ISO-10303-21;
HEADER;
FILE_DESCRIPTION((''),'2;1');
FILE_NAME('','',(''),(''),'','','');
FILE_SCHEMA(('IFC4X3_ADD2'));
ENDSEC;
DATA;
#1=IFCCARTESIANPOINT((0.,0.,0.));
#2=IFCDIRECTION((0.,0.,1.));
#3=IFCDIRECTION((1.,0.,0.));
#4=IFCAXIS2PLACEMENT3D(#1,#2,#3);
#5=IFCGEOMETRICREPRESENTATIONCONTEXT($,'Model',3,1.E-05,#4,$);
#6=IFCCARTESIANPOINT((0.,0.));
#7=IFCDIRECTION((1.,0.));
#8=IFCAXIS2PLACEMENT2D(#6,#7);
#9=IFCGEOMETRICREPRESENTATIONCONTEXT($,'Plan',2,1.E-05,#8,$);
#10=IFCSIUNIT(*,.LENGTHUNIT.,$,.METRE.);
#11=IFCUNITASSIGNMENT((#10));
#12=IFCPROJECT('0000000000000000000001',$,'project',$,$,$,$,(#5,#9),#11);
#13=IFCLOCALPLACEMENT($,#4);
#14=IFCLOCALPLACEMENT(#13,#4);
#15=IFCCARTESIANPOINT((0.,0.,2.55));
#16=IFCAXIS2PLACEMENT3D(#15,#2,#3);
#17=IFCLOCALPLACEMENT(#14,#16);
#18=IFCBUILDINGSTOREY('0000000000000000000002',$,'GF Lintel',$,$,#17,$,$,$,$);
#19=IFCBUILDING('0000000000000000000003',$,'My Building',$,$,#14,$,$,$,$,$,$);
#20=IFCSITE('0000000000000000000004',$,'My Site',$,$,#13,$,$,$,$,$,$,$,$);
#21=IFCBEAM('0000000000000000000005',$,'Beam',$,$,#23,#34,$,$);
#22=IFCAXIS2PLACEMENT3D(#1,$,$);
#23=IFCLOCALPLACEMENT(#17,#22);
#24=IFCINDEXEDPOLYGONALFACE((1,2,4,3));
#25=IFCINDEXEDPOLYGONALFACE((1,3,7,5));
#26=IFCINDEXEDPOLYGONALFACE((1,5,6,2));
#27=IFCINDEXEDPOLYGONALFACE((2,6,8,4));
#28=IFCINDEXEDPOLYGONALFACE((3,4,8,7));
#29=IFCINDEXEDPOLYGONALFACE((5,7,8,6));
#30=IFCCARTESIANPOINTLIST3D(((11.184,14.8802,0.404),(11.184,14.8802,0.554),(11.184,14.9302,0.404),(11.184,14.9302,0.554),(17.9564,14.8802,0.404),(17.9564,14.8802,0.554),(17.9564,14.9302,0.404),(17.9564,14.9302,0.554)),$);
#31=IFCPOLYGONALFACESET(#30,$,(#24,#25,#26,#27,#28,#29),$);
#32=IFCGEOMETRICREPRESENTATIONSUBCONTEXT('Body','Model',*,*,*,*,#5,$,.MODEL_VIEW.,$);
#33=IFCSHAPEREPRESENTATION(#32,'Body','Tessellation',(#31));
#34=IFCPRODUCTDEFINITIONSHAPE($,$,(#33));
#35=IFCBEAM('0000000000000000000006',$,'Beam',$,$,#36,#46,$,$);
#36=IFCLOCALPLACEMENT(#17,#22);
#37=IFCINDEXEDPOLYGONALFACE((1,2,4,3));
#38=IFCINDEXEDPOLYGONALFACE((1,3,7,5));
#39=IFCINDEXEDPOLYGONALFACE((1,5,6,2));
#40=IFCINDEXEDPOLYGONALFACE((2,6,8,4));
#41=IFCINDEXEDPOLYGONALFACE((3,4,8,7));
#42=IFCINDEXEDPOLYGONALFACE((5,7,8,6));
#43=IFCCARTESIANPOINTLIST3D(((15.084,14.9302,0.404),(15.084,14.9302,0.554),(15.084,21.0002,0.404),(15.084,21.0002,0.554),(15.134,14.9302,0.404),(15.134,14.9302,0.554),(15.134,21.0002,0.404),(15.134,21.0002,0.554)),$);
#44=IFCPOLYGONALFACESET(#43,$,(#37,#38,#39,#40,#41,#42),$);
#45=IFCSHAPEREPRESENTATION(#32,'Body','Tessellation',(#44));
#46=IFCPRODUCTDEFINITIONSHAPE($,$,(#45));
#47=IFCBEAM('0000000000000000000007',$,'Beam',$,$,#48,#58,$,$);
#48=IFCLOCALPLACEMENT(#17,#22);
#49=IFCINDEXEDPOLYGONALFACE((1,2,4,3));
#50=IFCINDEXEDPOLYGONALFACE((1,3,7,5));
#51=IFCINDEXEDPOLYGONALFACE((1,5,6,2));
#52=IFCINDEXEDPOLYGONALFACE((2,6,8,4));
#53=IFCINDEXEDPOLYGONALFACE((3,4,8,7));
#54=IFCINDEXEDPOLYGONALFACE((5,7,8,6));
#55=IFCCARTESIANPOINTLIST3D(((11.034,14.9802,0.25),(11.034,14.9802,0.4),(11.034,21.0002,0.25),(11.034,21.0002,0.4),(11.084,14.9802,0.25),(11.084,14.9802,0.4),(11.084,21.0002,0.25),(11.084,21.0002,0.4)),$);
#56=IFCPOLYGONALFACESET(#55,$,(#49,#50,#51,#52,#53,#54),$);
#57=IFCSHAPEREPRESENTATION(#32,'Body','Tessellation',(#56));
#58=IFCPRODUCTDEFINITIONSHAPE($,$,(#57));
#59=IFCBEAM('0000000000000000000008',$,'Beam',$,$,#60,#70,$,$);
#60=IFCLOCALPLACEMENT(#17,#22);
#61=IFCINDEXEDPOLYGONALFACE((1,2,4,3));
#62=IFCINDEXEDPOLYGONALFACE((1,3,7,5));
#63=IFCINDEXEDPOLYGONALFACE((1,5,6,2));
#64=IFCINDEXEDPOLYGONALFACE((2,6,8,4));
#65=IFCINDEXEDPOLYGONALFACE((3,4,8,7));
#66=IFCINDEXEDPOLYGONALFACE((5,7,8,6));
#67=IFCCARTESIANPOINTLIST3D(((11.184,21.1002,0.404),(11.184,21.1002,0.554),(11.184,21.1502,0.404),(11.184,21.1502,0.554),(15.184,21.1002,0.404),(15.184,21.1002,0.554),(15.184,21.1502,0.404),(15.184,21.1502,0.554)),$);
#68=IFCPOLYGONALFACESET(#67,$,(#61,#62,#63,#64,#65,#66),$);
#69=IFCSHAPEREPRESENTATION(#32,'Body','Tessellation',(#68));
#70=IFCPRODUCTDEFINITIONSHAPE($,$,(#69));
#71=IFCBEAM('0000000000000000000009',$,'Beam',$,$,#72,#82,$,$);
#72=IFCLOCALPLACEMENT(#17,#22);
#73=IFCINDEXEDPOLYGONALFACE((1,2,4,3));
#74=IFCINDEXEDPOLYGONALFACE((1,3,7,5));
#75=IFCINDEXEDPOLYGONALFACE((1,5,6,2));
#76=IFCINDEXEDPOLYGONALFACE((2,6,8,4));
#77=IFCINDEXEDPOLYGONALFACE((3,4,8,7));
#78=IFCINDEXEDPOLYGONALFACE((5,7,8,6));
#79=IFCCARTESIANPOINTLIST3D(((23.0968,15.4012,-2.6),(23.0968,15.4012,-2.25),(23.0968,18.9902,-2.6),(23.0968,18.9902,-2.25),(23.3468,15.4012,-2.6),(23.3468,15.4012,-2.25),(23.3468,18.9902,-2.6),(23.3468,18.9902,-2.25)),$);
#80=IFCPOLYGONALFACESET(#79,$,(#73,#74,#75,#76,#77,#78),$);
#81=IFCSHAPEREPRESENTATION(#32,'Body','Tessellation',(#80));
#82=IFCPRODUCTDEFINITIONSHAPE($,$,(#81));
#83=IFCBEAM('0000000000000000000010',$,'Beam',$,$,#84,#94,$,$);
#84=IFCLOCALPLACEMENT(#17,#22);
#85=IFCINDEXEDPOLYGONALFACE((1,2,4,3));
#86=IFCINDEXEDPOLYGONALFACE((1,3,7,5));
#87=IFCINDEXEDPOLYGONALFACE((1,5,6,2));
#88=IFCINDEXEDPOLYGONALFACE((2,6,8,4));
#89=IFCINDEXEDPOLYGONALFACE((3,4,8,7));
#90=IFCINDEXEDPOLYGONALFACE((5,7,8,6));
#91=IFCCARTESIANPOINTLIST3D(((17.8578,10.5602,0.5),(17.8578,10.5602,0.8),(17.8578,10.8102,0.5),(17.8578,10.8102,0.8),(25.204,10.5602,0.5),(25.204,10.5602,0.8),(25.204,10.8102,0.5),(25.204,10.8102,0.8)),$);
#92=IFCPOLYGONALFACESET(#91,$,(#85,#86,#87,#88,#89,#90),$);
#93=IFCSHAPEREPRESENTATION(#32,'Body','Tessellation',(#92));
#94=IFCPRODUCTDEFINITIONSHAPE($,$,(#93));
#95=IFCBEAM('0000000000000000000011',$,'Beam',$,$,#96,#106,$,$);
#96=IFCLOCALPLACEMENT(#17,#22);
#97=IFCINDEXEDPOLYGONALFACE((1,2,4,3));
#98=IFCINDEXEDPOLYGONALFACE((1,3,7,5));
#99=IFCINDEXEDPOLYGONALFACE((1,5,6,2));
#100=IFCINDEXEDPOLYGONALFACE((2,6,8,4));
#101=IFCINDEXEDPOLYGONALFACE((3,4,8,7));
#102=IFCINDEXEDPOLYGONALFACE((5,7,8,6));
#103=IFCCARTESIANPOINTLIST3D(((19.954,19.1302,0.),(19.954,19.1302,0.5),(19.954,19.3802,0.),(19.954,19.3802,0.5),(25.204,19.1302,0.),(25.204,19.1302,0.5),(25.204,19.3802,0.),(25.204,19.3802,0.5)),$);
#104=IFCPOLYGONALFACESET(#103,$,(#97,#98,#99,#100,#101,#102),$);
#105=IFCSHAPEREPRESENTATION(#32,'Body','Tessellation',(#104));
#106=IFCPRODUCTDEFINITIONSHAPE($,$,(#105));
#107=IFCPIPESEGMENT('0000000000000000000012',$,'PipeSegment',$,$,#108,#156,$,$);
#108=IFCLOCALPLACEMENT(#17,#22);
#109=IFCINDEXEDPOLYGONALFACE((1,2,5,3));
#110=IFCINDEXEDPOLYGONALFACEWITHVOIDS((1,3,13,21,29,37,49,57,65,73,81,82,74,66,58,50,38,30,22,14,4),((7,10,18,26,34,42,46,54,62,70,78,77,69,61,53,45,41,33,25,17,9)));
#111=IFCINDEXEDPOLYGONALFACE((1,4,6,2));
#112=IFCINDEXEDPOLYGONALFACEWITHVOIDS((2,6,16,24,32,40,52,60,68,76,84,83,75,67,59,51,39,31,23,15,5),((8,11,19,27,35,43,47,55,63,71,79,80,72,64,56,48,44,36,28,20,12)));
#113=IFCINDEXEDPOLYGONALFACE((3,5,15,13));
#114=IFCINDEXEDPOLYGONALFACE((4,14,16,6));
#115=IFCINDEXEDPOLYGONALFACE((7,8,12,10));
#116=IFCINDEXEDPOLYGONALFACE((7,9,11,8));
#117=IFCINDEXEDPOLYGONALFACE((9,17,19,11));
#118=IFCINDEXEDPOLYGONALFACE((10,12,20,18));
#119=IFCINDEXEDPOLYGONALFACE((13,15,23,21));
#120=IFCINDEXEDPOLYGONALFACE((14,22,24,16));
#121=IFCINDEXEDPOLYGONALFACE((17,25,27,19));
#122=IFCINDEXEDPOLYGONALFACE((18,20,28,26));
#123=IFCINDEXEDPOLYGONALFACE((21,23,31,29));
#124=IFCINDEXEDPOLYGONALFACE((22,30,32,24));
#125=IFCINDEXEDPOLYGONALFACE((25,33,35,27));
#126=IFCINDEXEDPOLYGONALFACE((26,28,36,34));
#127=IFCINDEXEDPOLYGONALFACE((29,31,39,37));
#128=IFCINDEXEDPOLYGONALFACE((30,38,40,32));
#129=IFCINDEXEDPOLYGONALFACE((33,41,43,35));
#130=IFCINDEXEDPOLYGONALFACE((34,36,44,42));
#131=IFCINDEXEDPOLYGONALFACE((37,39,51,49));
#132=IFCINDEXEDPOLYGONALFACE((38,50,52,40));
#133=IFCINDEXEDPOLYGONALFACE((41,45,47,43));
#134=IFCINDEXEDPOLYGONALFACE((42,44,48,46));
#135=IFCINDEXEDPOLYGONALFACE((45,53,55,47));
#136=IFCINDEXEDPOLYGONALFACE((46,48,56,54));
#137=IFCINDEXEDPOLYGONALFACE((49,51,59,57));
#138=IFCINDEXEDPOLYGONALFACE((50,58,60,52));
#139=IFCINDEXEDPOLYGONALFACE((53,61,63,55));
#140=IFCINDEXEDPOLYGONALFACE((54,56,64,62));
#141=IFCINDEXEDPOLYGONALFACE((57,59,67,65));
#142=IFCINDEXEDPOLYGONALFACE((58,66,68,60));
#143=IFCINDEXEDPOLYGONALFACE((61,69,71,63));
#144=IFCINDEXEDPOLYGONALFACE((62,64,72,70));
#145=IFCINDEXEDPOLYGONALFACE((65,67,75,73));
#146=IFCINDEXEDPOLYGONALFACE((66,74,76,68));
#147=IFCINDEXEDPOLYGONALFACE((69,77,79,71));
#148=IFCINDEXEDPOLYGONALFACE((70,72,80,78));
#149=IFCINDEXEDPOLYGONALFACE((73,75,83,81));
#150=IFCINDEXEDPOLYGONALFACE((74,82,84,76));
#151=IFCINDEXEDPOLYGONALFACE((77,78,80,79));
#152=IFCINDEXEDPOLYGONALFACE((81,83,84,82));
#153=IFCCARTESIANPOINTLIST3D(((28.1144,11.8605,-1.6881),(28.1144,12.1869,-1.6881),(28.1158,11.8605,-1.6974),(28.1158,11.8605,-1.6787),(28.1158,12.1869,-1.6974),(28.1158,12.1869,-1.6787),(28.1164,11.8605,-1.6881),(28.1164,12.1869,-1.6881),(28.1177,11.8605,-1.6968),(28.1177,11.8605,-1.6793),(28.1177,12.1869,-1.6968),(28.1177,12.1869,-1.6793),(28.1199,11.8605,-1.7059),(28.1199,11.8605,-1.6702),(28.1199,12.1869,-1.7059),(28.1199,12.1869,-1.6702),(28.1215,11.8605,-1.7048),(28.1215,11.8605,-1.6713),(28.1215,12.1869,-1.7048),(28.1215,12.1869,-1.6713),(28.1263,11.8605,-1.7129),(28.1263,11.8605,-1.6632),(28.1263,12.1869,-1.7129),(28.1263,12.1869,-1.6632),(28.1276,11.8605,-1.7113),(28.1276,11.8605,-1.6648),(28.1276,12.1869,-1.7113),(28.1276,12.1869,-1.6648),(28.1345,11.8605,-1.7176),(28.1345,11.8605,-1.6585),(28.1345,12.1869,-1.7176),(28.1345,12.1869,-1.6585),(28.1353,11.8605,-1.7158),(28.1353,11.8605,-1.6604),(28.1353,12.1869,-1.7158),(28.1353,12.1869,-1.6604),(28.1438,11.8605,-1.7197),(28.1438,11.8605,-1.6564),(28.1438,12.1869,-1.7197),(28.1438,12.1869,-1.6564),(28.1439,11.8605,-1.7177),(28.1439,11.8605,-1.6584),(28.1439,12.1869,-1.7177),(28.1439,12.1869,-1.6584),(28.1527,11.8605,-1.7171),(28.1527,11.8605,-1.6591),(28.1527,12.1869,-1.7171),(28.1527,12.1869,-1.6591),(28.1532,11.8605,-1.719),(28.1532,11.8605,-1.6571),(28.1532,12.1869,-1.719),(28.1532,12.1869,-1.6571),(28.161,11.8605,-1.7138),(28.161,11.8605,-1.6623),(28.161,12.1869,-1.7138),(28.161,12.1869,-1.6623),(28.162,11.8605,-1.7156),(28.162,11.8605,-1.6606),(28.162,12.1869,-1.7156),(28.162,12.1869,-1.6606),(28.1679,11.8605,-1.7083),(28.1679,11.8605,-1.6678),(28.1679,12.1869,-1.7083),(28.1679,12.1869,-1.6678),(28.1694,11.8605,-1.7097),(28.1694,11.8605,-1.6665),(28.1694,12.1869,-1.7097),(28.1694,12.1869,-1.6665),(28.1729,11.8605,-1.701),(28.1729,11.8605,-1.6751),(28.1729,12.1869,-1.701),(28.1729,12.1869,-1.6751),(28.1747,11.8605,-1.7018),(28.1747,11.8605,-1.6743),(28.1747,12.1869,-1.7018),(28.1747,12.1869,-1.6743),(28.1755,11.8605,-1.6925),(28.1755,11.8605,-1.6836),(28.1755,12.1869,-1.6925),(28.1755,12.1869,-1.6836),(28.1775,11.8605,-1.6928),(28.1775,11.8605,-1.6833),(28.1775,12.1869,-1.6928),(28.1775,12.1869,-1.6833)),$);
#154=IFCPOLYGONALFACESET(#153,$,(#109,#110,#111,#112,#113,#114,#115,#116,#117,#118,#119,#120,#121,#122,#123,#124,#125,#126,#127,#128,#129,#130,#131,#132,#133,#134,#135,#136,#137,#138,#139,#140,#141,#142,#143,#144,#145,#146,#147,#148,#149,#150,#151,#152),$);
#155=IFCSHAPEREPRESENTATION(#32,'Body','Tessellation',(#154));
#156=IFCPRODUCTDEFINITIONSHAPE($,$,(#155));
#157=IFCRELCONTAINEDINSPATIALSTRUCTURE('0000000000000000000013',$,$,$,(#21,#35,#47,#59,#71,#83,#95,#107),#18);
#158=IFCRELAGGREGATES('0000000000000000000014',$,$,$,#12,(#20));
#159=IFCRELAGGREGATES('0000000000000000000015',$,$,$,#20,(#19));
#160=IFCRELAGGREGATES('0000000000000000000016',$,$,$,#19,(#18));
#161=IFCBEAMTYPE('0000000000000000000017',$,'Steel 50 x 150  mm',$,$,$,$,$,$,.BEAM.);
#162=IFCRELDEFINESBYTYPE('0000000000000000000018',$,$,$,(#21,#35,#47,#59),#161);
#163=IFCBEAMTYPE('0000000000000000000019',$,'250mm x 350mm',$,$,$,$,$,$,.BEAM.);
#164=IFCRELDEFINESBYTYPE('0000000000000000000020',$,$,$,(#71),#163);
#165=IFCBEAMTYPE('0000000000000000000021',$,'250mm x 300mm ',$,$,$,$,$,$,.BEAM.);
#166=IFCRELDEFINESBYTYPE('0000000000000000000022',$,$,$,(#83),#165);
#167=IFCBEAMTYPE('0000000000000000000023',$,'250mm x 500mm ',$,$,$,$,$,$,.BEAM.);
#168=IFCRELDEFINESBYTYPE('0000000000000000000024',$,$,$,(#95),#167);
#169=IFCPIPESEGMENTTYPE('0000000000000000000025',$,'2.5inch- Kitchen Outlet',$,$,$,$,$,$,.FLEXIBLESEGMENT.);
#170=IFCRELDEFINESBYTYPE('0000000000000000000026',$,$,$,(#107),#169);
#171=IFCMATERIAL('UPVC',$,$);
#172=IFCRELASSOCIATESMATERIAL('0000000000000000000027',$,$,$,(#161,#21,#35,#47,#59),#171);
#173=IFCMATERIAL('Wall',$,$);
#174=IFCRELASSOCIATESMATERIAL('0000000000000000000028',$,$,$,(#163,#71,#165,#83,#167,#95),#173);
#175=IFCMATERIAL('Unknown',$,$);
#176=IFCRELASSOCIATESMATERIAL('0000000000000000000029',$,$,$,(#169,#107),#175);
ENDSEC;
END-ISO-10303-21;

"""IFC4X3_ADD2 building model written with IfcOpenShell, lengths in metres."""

from ifc_helpers import new_model, si_unit, frame, origin_with_axes, origin_2d_with_axis, place, context, subcontext, project, spatial, rectangle, hollow_circle, extrude, material, material_profile, profile_set, profile_usage, type_object, element, save


model = new_model("IFC4X3_ADD2")

# Units and contexts
model_context = context("Model", 3, precision=1e-05, world=origin_with_axes())
plan_context = context("Plan", 2, precision=1e-05, world=origin_2d_with_axis())
body_context = subcontext(model_context, "Body", "Model", "MODEL_VIEW")
ifc_project = project(units=[si_unit("LENGTHUNIT", "METRE")], contexts=[model_context, plan_context])

# Site, building, storey
site_placement = place(None, origin_with_axes())
site = spatial("IfcSite", under=ifc_project, at=site_placement, Name="My Site")
building_placement = place(site_placement, origin_with_axes())
building = spatial("IfcBuilding", under=site, at=building_placement, Name="My Building")
storey_placement = place(building_placement, frame((0.0, 0.0, 2.55), z_axis=(0.0, 0.0, 1.0), x_axis=(1.0, 0.0, 0.0)))
storey = spatial("IfcBuildingStorey", under=building, at=storey_placement, Name="GF Lintel")

# Beams
ifc_material_1 = material(Name="UPVC")
ifc_material_profile_1 = material_profile(ifc_material_1, rectangle(XDim=0.05, YDim=0.15))
ifc_profile_set_1 = profile_set([ifc_material_profile_1])
ifc_profile_usage_1 = profile_usage(ifc_profile_set_1)
beam_type_1 = type_object("IfcBeamType", Name="Steel 50 x 150  mm", PredefinedType="BEAM", material=ifc_profile_set_1)
beam_1_placement = place(storey_placement, frame((11.184, 14.9052, 0.479), z_axis=(1.0, 0.0, 0.0), x_axis=(0.0, 1.0, 0.0)))
element("IfcBeam", 1, at=beam_1_placement, inside=storey, type_object=beam_type_1, material=ifc_profile_usage_1, Name="Beam", context=body_context, shape_type="SweptSolid", body=[
    extrude(rectangle(XDim=0.05, YDim=0.15), origin_with_axes(), (0.0, 0.0, 1.0), 6.7724),
])
ifc_profile_usage_2 = profile_usage(ifc_profile_set_1)
beam_2_placement = place(storey_placement, frame((15.109, 14.9302, 0.479), z_axis=(0.0, 1.0, 0.0), x_axis=(-1.0, 0.0, 0.0)))
element("IfcBeam", 2, at=beam_2_placement, inside=storey, type_object=beam_type_1, material=ifc_profile_usage_2, Name="Beam", context=body_context, shape_type="SweptSolid", body=[
    extrude(rectangle(XDim=0.05, YDim=0.15), origin_with_axes(), (0.0, 0.0, 1.0), 6.07),
])
ifc_profile_usage_3 = profile_usage(ifc_profile_set_1)
beam_3_placement = place(storey_placement, frame((11.059, 14.9802, 0.325), z_axis=(0.0, 1.0, 0.0), x_axis=(-1.0, 0.0, 0.0)))
element("IfcBeam", 3, at=beam_3_placement, inside=storey, type_object=beam_type_1, material=ifc_profile_usage_3, Name="Beam", context=body_context, shape_type="SweptSolid", body=[
    extrude(rectangle(XDim=0.05, YDim=0.15), origin_with_axes(), (0.0, 0.0, 1.0), 6.02),
])
ifc_profile_usage_4 = profile_usage(ifc_profile_set_1)
beam_4_placement = place(storey_placement, frame((11.184, 21.1252, 0.479), z_axis=(1.0, 0.0, 0.0), x_axis=(0.0, 1.0, 0.0)))
element("IfcBeam", 4, at=beam_4_placement, inside=storey, type_object=beam_type_1, material=ifc_profile_usage_4, Name="Beam", context=body_context, shape_type="SweptSolid", body=[
    extrude(rectangle(XDim=0.05, YDim=0.15), origin_with_axes(), (0.0, 0.0, 1.0), 4.0),
])
ifc_material_2 = material(Name="Wall")
ifc_material_profile_2 = material_profile(ifc_material_2, rectangle(XDim=0.25, YDim=0.35))
ifc_profile_set_2 = profile_set([ifc_material_profile_2], Name="concrete")
ifc_profile_usage_5 = profile_usage(ifc_profile_set_2)
beam_type_2 = type_object("IfcBeamType", Name="250mm x 350mm", PredefinedType="BEAM", material=ifc_profile_set_2)
beam_5_placement = place(storey_placement, frame((23.2218, 15.4012, -2.425), z_axis=(0.0, 1.0, 0.0), x_axis=(-1.0, 0.0, 0.0)))
element("IfcBeam", 5, at=beam_5_placement, inside=storey, type_object=beam_type_2, material=ifc_profile_usage_5, Name="Beam", context=body_context, shape_type="SweptSolid", body=[
    extrude(rectangle(XDim=0.25, YDim=0.35), origin_with_axes(), (0.0, 0.0, 1.0), 3.589),
])
ifc_material_profile_3 = material_profile(ifc_material_2, rectangle(XDim=0.25, YDim=0.3))
ifc_profile_set_3 = profile_set([ifc_material_profile_3], Name="concrete")
ifc_profile_usage_6 = profile_usage(ifc_profile_set_3)
beam_type_3 = type_object("IfcBeamType", Name="250mm x 300mm ", PredefinedType="BEAM", material=ifc_profile_set_3)
beam_6_placement = place(storey_placement, frame((25.204, 10.6852, 0.65), z_axis=(-1.0, 0.0, 0.0), x_axis=(0.0, -1.0, 0.0)))
element("IfcBeam", 6, at=beam_6_placement, inside=storey, type_object=beam_type_3, material=ifc_profile_usage_6, Name="Beam", context=body_context, shape_type="SweptSolid", body=[
    extrude(rectangle(XDim=0.25, YDim=0.3), origin_with_axes(), (0.0, 0.0, 1.0), 7.3462),
])
ifc_material_profile_4 = material_profile(ifc_material_2, rectangle(XDim=0.25, YDim=0.5))
ifc_profile_set_4 = profile_set([ifc_material_profile_4])
ifc_profile_usage_7 = profile_usage(ifc_profile_set_4, cardinal=5)
beam_type_4 = type_object("IfcBeamType", Name="250mm x 500mm ", PredefinedType="BEAM", material=ifc_profile_set_4)
beam_7_placement = place(storey_placement, frame((25.204, 19.2552, 0.25), z_axis=(-1.0, 0.0, 0.0), x_axis=(0.0, -1.0, 0.0)))
element("IfcBeam", 7, at=beam_7_placement, inside=storey, type_object=beam_type_4, material=ifc_profile_usage_7, Name="Beam", context=body_context, shape_type="SweptSolid", body=[
    extrude(rectangle(XDim=0.25, YDim=0.5), origin_with_axes(), (0.0, 0.0, 1.0), 5.25),
])

# Pipe segment
ifc_material_3 = material(Name="Unknown")
ifc_material_profile_5 = material_profile(ifc_material_3, hollow_circle(Radius=0.0318, WallThickness=0.002))
ifc_profile_set_5 = profile_set([ifc_material_profile_5])
ifc_profile_usage_8 = profile_usage(ifc_profile_set_5)
pipe_segment_type_1 = type_object("IfcPipeSegmentType", Name="2.5inch- Kitchen Outlet", PredefinedType="FLEXIBLESEGMENT", material=ifc_profile_set_5)
pipe_segment_1_placement = place(storey_placement, frame((28.1461, 11.8605, -1.6881), z_axis=(0.0, 1.0, 0.0), x_axis=(-1.0, 0.0, 0.0)))
element("IfcPipeSegment", 8, at=pipe_segment_1_placement, inside=storey, type_object=pipe_segment_type_1, material=ifc_profile_usage_8, Name="PipeSegment", context=body_context, shape_type="SweptSolid", body=[
    extrude(hollow_circle(Radius=0.0318, WallThickness=0.002), origin_with_axes(), (0.0, 0.0, 1.0), 0.3263),
])

save(model, "model.ifc")
